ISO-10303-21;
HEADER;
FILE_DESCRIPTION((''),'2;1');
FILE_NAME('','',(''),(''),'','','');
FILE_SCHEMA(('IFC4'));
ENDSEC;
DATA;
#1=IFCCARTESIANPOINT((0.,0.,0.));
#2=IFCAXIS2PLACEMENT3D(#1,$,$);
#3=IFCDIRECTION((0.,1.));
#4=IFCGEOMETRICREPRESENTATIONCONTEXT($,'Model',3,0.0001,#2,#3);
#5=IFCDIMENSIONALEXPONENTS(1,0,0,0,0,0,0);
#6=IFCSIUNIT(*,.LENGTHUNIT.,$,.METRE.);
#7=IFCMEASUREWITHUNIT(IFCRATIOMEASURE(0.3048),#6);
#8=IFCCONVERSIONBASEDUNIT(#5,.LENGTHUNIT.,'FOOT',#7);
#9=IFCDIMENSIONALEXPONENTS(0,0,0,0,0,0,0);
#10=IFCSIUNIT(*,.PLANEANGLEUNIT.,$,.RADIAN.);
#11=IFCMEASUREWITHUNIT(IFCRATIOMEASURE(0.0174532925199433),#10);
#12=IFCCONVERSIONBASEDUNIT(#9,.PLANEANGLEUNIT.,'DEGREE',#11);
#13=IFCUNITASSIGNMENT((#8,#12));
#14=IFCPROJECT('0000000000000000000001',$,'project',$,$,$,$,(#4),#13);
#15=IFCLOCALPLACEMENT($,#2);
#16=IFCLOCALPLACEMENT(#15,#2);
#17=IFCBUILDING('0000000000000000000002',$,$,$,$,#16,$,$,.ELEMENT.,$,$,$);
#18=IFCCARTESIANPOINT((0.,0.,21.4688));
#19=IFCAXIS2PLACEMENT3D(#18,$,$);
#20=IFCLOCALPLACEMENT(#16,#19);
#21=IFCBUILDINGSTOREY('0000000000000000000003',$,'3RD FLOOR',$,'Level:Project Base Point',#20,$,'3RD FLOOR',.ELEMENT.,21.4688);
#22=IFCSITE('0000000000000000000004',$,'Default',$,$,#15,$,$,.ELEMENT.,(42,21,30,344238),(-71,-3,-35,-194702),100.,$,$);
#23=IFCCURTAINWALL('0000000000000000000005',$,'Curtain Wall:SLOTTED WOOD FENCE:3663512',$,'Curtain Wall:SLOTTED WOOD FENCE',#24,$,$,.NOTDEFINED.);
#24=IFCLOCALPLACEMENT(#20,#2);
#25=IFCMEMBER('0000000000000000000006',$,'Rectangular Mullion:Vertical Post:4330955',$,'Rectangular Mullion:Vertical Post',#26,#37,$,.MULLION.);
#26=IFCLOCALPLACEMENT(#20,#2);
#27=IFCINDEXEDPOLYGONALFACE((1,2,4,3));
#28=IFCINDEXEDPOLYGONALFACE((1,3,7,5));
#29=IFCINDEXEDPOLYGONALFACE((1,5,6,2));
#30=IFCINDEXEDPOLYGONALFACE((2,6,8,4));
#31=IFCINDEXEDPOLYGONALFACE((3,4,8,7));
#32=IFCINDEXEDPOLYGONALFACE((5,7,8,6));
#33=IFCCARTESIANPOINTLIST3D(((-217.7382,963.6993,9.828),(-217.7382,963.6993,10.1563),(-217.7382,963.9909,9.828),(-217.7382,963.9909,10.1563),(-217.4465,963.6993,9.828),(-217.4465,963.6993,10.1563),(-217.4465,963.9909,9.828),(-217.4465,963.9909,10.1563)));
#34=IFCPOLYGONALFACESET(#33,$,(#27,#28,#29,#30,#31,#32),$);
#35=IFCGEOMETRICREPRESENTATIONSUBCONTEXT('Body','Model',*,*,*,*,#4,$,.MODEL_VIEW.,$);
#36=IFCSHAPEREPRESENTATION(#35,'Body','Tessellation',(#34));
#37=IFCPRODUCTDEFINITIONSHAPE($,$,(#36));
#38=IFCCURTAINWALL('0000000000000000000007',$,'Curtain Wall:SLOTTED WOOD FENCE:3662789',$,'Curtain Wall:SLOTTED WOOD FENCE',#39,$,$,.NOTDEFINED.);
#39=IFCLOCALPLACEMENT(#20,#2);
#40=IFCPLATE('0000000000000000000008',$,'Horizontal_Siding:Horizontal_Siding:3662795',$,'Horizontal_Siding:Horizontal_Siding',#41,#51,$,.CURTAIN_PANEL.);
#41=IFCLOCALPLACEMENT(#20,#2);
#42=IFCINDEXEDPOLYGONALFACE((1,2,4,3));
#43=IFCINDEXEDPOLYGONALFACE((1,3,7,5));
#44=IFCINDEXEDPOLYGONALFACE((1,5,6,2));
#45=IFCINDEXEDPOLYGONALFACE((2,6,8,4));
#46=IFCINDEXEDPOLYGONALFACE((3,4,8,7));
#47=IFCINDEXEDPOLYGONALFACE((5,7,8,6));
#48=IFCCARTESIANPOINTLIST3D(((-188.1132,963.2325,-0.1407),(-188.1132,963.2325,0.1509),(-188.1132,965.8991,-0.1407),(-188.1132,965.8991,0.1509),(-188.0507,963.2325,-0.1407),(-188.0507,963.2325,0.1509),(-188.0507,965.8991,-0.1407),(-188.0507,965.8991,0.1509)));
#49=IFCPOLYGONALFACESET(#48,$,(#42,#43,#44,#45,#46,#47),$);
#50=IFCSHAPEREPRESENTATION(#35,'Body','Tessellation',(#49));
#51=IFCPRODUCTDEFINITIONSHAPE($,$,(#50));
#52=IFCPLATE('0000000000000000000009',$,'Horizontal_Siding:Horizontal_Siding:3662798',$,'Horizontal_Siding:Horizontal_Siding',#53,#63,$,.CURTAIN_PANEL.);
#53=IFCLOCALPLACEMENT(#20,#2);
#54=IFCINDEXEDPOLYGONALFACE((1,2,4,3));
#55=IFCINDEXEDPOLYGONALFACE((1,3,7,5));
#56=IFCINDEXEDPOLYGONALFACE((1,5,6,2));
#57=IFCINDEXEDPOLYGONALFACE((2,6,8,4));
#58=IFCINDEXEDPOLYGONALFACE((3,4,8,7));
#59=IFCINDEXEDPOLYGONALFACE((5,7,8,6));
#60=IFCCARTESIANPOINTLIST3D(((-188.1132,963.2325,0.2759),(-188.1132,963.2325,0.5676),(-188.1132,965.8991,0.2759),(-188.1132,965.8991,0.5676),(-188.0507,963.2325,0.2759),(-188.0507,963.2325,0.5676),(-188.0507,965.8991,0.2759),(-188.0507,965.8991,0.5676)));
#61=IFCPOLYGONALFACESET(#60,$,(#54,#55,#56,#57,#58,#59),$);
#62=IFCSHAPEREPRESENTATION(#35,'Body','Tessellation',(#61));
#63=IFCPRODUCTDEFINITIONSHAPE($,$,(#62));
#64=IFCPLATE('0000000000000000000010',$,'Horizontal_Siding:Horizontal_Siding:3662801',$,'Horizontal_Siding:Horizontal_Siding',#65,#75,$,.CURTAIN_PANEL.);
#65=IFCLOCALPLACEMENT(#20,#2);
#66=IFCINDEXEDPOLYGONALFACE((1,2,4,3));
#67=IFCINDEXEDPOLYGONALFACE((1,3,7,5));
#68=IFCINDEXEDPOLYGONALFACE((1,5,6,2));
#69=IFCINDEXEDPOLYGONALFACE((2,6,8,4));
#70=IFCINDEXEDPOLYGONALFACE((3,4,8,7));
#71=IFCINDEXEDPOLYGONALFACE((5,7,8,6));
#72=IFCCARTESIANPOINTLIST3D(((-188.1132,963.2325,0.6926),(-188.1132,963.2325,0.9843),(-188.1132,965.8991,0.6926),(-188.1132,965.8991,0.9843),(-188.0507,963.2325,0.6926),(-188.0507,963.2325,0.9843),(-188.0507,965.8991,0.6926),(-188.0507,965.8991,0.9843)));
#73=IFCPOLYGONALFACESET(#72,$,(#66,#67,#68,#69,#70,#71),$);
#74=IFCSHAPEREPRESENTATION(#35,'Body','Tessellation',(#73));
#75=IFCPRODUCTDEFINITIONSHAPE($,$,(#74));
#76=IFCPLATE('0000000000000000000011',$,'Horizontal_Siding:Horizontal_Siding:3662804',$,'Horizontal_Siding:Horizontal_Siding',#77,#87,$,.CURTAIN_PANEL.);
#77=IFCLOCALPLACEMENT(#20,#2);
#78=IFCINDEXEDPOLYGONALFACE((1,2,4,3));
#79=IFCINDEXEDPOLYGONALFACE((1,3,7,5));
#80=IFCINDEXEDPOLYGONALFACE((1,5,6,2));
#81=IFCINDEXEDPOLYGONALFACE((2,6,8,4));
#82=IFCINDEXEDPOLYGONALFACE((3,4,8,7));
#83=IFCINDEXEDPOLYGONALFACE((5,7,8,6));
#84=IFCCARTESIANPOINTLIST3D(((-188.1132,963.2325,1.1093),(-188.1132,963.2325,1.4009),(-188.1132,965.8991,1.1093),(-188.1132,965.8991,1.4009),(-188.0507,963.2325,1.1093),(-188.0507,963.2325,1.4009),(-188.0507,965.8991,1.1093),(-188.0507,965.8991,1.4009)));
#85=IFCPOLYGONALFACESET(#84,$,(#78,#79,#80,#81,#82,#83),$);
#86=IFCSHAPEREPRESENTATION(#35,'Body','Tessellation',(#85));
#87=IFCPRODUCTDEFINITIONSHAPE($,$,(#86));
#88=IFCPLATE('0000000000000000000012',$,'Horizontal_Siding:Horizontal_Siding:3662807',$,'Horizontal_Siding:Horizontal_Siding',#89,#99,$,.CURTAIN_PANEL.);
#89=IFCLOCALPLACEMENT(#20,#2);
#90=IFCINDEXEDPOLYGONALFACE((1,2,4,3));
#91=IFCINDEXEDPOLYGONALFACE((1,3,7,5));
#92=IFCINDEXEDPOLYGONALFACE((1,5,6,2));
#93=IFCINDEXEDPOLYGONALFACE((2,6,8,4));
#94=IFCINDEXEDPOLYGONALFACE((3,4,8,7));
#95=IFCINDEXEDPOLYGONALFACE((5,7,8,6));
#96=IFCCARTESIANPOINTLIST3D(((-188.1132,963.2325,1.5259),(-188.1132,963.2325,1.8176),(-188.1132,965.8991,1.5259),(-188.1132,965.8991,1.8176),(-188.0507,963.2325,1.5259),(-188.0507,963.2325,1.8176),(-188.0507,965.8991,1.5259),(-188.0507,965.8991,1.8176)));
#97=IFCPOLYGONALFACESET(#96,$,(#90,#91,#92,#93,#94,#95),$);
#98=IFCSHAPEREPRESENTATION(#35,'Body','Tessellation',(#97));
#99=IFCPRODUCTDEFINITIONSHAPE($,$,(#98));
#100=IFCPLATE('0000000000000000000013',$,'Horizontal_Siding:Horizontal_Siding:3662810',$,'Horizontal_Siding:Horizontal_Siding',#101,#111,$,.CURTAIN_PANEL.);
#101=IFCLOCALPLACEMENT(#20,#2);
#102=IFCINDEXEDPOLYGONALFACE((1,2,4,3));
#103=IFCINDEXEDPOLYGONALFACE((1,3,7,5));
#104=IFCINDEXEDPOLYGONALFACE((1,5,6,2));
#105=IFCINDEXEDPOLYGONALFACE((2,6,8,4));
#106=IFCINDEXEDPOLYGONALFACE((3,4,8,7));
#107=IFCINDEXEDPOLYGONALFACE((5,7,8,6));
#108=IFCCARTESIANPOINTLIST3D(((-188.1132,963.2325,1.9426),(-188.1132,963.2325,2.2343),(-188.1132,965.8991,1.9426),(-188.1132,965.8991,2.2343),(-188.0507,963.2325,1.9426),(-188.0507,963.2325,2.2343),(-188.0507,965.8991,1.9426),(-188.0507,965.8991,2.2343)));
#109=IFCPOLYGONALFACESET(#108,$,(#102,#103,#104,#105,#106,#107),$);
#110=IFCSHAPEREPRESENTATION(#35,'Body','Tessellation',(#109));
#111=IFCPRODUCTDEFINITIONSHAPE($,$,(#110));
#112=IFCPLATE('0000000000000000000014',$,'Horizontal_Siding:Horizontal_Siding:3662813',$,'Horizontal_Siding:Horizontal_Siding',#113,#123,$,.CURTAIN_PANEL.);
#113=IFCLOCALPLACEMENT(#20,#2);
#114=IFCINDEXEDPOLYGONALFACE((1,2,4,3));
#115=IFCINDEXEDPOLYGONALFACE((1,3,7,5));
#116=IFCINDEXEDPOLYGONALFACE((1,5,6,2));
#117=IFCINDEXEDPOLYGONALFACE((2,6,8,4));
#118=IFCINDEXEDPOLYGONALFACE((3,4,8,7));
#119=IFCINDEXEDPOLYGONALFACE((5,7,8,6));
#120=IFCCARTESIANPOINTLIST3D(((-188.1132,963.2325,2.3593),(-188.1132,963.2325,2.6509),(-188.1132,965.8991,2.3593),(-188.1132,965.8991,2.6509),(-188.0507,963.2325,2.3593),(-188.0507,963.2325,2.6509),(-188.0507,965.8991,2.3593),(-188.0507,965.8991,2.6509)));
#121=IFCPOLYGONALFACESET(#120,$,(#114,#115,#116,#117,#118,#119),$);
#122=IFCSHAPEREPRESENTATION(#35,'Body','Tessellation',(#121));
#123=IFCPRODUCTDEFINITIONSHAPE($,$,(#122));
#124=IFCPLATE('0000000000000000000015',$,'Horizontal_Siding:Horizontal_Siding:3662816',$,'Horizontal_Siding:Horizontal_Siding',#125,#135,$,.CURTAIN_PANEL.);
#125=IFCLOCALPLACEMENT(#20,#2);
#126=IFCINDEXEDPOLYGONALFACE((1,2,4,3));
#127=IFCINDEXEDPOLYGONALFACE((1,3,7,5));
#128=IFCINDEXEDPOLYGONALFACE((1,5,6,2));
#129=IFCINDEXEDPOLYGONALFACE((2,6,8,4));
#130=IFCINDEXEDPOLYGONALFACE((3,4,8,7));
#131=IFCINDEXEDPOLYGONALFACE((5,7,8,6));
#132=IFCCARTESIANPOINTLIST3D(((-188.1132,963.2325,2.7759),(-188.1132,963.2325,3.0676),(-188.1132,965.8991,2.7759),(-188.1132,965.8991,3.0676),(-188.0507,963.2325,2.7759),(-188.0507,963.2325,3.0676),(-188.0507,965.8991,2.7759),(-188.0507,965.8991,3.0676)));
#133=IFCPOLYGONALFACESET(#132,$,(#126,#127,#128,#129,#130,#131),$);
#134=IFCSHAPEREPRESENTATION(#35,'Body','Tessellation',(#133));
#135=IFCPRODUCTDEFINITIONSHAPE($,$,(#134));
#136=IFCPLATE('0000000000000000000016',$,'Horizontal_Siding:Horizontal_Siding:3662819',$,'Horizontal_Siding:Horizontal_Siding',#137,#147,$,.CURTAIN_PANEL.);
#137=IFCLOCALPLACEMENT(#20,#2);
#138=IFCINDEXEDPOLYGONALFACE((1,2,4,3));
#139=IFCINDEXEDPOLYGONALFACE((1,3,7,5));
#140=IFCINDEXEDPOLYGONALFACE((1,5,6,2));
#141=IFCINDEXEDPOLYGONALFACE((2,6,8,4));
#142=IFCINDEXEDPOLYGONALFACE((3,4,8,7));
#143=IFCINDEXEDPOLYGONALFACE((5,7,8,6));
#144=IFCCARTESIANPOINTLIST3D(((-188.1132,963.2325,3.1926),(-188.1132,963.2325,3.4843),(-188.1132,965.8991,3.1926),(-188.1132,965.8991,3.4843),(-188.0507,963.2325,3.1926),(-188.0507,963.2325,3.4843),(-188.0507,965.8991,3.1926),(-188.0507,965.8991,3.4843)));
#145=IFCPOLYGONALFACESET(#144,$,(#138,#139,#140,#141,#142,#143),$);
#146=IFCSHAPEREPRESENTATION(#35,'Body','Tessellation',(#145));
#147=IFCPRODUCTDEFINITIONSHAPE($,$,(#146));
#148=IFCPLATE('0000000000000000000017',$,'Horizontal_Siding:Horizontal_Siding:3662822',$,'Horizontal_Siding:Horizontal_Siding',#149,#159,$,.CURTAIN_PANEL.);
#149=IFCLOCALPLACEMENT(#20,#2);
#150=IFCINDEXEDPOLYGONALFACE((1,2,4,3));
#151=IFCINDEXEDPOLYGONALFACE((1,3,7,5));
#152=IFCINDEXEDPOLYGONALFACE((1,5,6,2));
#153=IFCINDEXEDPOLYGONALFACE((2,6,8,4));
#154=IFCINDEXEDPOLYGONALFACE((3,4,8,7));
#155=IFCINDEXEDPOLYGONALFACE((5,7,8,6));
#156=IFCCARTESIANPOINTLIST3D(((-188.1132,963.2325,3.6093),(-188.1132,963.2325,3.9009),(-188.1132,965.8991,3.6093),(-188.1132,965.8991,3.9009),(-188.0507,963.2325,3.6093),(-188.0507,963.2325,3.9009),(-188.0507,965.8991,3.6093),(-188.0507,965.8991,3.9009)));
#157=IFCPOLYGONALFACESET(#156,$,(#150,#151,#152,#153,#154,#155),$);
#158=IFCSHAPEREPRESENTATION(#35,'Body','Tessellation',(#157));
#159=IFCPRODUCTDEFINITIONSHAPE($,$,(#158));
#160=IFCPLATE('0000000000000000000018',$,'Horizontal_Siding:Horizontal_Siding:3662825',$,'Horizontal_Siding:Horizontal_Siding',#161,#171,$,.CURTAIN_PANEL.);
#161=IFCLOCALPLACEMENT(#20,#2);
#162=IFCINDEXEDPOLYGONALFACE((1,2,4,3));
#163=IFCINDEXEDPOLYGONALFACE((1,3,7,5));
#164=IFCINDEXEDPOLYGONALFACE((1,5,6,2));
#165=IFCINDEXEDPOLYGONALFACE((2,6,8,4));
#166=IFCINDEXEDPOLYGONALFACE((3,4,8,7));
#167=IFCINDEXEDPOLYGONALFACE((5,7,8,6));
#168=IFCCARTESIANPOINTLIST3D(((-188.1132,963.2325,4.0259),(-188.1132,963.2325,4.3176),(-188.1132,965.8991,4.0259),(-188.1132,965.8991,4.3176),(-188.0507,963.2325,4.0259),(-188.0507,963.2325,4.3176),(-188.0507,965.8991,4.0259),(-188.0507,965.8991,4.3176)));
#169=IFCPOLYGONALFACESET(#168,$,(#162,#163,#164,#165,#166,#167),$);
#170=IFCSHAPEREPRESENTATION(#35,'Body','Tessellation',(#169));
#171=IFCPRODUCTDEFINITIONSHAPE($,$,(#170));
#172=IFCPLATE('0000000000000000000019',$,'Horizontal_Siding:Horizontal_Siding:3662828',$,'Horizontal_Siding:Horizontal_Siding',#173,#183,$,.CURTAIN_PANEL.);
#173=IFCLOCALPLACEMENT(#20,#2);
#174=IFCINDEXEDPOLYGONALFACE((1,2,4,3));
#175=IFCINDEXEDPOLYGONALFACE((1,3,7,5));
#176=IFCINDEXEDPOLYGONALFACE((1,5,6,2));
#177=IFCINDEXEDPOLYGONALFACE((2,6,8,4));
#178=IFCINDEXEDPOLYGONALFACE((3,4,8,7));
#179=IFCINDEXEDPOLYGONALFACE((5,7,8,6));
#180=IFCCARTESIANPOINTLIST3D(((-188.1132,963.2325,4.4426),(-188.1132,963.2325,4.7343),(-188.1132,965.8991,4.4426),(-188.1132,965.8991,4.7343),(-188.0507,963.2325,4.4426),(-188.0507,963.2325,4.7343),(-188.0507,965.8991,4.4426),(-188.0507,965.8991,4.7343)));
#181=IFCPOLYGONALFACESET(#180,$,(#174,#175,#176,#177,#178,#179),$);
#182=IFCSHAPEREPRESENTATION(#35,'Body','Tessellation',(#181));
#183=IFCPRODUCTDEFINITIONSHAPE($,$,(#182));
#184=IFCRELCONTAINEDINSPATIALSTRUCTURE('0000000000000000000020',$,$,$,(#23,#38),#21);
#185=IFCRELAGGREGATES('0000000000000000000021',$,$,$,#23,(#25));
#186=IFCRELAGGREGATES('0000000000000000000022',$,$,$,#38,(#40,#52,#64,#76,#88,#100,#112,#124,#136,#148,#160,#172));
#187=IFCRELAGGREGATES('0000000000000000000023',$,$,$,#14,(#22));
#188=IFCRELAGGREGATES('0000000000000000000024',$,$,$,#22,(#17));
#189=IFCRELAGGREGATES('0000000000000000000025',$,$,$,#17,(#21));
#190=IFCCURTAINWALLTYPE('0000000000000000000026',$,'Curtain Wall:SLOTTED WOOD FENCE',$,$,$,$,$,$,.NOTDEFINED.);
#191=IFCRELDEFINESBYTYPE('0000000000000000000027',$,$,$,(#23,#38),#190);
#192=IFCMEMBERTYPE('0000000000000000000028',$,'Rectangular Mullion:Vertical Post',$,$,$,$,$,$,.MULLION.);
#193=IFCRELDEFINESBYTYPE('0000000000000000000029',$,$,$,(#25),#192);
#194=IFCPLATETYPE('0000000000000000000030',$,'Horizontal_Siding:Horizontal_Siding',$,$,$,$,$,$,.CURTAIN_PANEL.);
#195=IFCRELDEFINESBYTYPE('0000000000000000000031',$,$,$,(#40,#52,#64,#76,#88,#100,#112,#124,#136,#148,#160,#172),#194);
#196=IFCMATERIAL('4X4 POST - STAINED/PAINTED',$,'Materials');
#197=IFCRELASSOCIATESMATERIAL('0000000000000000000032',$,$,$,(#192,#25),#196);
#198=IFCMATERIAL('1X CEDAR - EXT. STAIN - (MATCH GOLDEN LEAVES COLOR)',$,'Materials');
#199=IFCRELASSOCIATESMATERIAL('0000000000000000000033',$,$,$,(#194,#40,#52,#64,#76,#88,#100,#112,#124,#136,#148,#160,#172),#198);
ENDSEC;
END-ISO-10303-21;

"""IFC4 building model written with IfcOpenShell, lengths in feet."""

from ifc_helpers import new_model, entity, si_unit, converted_unit, direction, frame, origin, origin_2d_with_axis, place, context, subcontext, project, spatial, rectangle, extrude, source, transform, mapped, material, material_profile, profile_set, profile_usage, type_object, type_shapes, element, aggregate, save


model = new_model("IFC4")

# Units and contexts
model_context = context("Model", 3, precision=0.0001, world=origin(), true_north=direction((0.0, 1.0)))
body_context = subcontext(model_context, "Body", "Model", "MODEL_VIEW")
ifc_project = project(units=[converted_unit("LENGTHUNIT", "FOOT", entity("IfcRatioMeasure", 0.3048), si_unit("LENGTHUNIT", "METRE"), dimensions=[1, 0, 0, 0, 0, 0, 0]), converted_unit("PLANEANGLEUNIT", "DEGREE", entity("IfcRatioMeasure", 0.0174532925199433), si_unit("PLANEANGLEUNIT", "RADIAN"), dimensions=[0, 0, 0, 0, 0, 0, 0])], contexts=[model_context])

# Site, building, storey
site_placement = place(None, origin())
site = spatial("IfcSite", under=ifc_project, at=site_placement, Name="Default", CompositionType="ELEMENT", RefLatitude=(42, 21, 30, 344238), RefLongitude=(-71, -3, -35, -194702), RefElevation=100.0)
building_placement = place(site_placement, origin())
building = spatial("IfcBuilding", under=site, at=building_placement, CompositionType="ELEMENT")
storey_placement = place(building_placement, frame((0.0, 0.0, 21.4688)))
storey = spatial("IfcBuildingStorey", under=building, at=storey_placement, Name="3RD FLOOR", ObjectType="Level:Project Base Point", LongName="3RD FLOOR", CompositionType="ELEMENT", Elevation=21.4688)

# Curtain wall, member
curtain_wall_type = type_object("IfcCurtainWallType", Name="Curtain Wall:SLOTTED WOOD FENCE", PredefinedType="NOTDEFINED")
curtain_wall_1_placement = place(storey_placement, frame((0.0, 0.0, -21.4688)))
curtain_wall_1 = element("IfcCurtainWall", 1, at=curtain_wall_1_placement, inside=storey, type_object=curtain_wall_type, Name="Curtain Wall:SLOTTED WOOD FENCE:3663512", ObjectType="Curtain Wall:SLOTTED WOOD FENCE", PredefinedType="NOTDEFINED")
ifc_material_1 = material(Name="4X4 POST - STAINED/PAINTED", Category="Materials")
ifc_material_profile = material_profile(ifc_material_1, rectangle(XDim=0.2917, YDim=0.2917, at=origin_2d_with_axis()), Name="Vertical Post")
ifc_profile_set = profile_set([ifc_material_profile], Name="Vertical Post")
ifc_profile_usage_1 = profile_usage(ifc_profile_set)
member_type_1 = type_object("IfcMemberType", Name="Rectangular Mullion:Vertical Post", PredefinedType="MULLION", material=ifc_profile_set)
shared_shape_1 = source(origin(), body_context, "Body", "SweptSolid", [
    extrude(rectangle(XDim=0.2917, YDim=0.2917, at=origin_2d_with_axis()), frame((0.0, -0.2083, -0.3282), z_axis=(0.0, 0.0, 1.0), x_axis=(0.0, -1.0, 0.0)), (0.0, 0.0, 1.0), 0.3282),
])
type_shapes(member_type_1, [shared_shape_1])
member_1_placement = place(storey_placement, frame((-217.8007, 963.8451, 9.828), z_axis=(0.0, 0.0, -1.0), x_axis=(0.0, -1.0, 0.0)))
member_1 = element("IfcMember", 2, at=member_1_placement, type_object=member_type_1, material=ifc_profile_usage_1, Name="Rectangular Mullion:Vertical Post:4330955", ObjectType="Rectangular Mullion:Vertical Post", PredefinedType="MULLION", context=body_context, shape_type="MappedRepresentation", body=[
    mapped(shared_shape_1, transform((0.0, 0.0, 0.0), scale=1.0)),
])
aggregate(curtain_wall_1, [member_1])

# Curtain wall, plates
curtain_wall_2_placement = place(storey_placement, frame((0.0, 0.0, -21.4688)))
curtain_wall_2 = element("IfcCurtainWall", 3, at=curtain_wall_2_placement, inside=storey, type_object=curtain_wall_type, Name="Curtain Wall:SLOTTED WOOD FENCE:3662789", ObjectType="Curtain Wall:SLOTTED WOOD FENCE", PredefinedType="NOTDEFINED")
ifc_material_2 = material(Name="1X CEDAR - EXT. STAIN - (MATCH GOLDEN LEAVES COLOR)", Category="Materials")
plate_type = type_object("IfcPlateType", Name="Horizontal_Siding:Horizontal_Siding", PredefinedType="CURTAIN_PANEL", material=ifc_material_2)
shared_shape_2 = source(origin(), body_context, "Body", "SweptSolid", [
    extrude(rectangle(XDim=0.0625, YDim=2.6667, at=origin_2d_with_axis()), frame((1.3333, 0.0312, 0.0), z_axis=(0.0, 0.0, 1.0), x_axis=(0.0, 1.0, 0.0)), (0.0, 0.0, 1.0), 0.2917),
])
type_shapes(plate_type, [shared_shape_2])
plate_1_placement = place(curtain_wall_2_placement, frame((-188.1132, 965.8991, 21.328), z_axis=(0.0, 0.0, 1.0), x_axis=(0.0, -1.0, 0.0)))
plate_1 = element("IfcPlate", 4, at=plate_1_placement, type_object=plate_type, material=ifc_material_2, Name="Horizontal_Siding:Horizontal_Siding:3662795", ObjectType="Horizontal_Siding:Horizontal_Siding", PredefinedType="CURTAIN_PANEL", context=body_context, shape_type="MappedRepresentation", body=[
    mapped(shared_shape_2, transform((0.0, 0.0, 0.0), scale=1.0)),
])
plate_2_placement = place(curtain_wall_2_placement, frame((-188.1132, 965.8991, 21.7447), z_axis=(0.0, 0.0, 1.0), x_axis=(0.0, -1.0, 0.0)))
plate_2 = element("IfcPlate", 5, at=plate_2_placement, type_object=plate_type, material=ifc_material_2, Name="Horizontal_Siding:Horizontal_Siding:3662798", ObjectType="Horizontal_Siding:Horizontal_Siding", PredefinedType="CURTAIN_PANEL", context=body_context, shape_type="MappedRepresentation", body=[
    mapped(shared_shape_2, transform((0.0, 0.0, 0.0), scale=1.0)),
])
plate_3_placement = place(curtain_wall_2_placement, frame((-188.1132, 965.8991, 22.1613), z_axis=(0.0, 0.0, 1.0), x_axis=(0.0, -1.0, 0.0)))
plate_3 = element("IfcPlate", 6, at=plate_3_placement, type_object=plate_type, material=ifc_material_2, Name="Horizontal_Siding:Horizontal_Siding:3662801", ObjectType="Horizontal_Siding:Horizontal_Siding", PredefinedType="CURTAIN_PANEL", context=body_context, shape_type="MappedRepresentation", body=[
    mapped(shared_shape_2, transform((0.0, 0.0, 0.0), scale=1.0)),
])
plate_4_placement = place(curtain_wall_2_placement, frame((-188.1132, 965.8991, 22.578), z_axis=(0.0, 0.0, 1.0), x_axis=(0.0, -1.0, 0.0)))
plate_4 = element("IfcPlate", 7, at=plate_4_placement, type_object=plate_type, material=ifc_material_2, Name="Horizontal_Siding:Horizontal_Siding:3662804", ObjectType="Horizontal_Siding:Horizontal_Siding", PredefinedType="CURTAIN_PANEL", context=body_context, shape_type="MappedRepresentation", body=[
    mapped(shared_shape_2, transform((0.0, 0.0, 0.0), scale=1.0)),
])
plate_5_placement = place(curtain_wall_2_placement, frame((-188.1132, 965.8991, 22.9947), z_axis=(0.0, 0.0, 1.0), x_axis=(0.0, -1.0, 0.0)))
plate_5 = element("IfcPlate", 8, at=plate_5_placement, type_object=plate_type, material=ifc_material_2, Name="Horizontal_Siding:Horizontal_Siding:3662807", ObjectType="Horizontal_Siding:Horizontal_Siding", PredefinedType="CURTAIN_PANEL", context=body_context, shape_type="MappedRepresentation", body=[
    mapped(shared_shape_2, transform((0.0, 0.0, 0.0), scale=1.0)),
])
plate_6_placement = place(curtain_wall_2_placement, frame((-188.1132, 965.8991, 23.4113), z_axis=(0.0, 0.0, 1.0), x_axis=(0.0, -1.0, 0.0)))
plate_6 = element("IfcPlate", 9, at=plate_6_placement, type_object=plate_type, material=ifc_material_2, Name="Horizontal_Siding:Horizontal_Siding:3662810", ObjectType="Horizontal_Siding:Horizontal_Siding", PredefinedType="CURTAIN_PANEL", context=body_context, shape_type="MappedRepresentation", body=[
    mapped(shared_shape_2, transform((0.0, 0.0, 0.0), scale=1.0)),
])
plate_7_placement = place(curtain_wall_2_placement, frame((-188.1132, 965.8991, 23.828), z_axis=(0.0, 0.0, 1.0), x_axis=(0.0, -1.0, 0.0)))
plate_7 = element("IfcPlate", 10, at=plate_7_placement, type_object=plate_type, material=ifc_material_2, Name="Horizontal_Siding:Horizontal_Siding:3662813", ObjectType="Horizontal_Siding:Horizontal_Siding", PredefinedType="CURTAIN_PANEL", context=body_context, shape_type="MappedRepresentation", body=[
    mapped(shared_shape_2, transform((0.0, 0.0, 0.0), scale=1.0)),
])
plate_8_placement = place(curtain_wall_2_placement, frame((-188.1132, 965.8991, 24.2447), z_axis=(0.0, 0.0, 1.0), x_axis=(0.0, -1.0, 0.0)))
plate_8 = element("IfcPlate", 11, at=plate_8_placement, type_object=plate_type, material=ifc_material_2, Name="Horizontal_Siding:Horizontal_Siding:3662816", ObjectType="Horizontal_Siding:Horizontal_Siding", PredefinedType="CURTAIN_PANEL", context=body_context, shape_type="MappedRepresentation", body=[
    mapped(shared_shape_2, transform((0.0, 0.0, 0.0), scale=1.0)),
])
plate_9_placement = place(curtain_wall_2_placement, frame((-188.1132, 965.8991, 24.6613), z_axis=(0.0, 0.0, 1.0), x_axis=(0.0, -1.0, 0.0)))
plate_9 = element("IfcPlate", 12, at=plate_9_placement, type_object=plate_type, material=ifc_material_2, Name="Horizontal_Siding:Horizontal_Siding:3662819", ObjectType="Horizontal_Siding:Horizontal_Siding", PredefinedType="CURTAIN_PANEL", context=body_context, shape_type="MappedRepresentation", body=[
    mapped(shared_shape_2, transform((0.0, 0.0, 0.0), scale=1.0)),
])
plate_10_placement = place(curtain_wall_2_placement, frame((-188.1132, 965.8991, 25.078), z_axis=(0.0, 0.0, 1.0), x_axis=(0.0, -1.0, 0.0)))
plate_10 = element("IfcPlate", 13, at=plate_10_placement, type_object=plate_type, material=ifc_material_2, Name="Horizontal_Siding:Horizontal_Siding:3662822", ObjectType="Horizontal_Siding:Horizontal_Siding", PredefinedType="CURTAIN_PANEL", context=body_context, shape_type="MappedRepresentation", body=[
    mapped(shared_shape_2, transform((0.0, 0.0, 0.0), scale=1.0)),
])
plate_11_placement = place(curtain_wall_2_placement, frame((-188.1132, 965.8991, 25.4947), z_axis=(0.0, 0.0, 1.0), x_axis=(0.0, -1.0, 0.0)))
plate_11 = element("IfcPlate", 14, at=plate_11_placement, type_object=plate_type, material=ifc_material_2, Name="Horizontal_Siding:Horizontal_Siding:3662825", ObjectType="Horizontal_Siding:Horizontal_Siding", PredefinedType="CURTAIN_PANEL", context=body_context, shape_type="MappedRepresentation", body=[
    mapped(shared_shape_2, transform((0.0, 0.0, 0.0), scale=1.0)),
])
plate_12_placement = place(curtain_wall_2_placement, frame((-188.1132, 965.8991, 25.9113), z_axis=(0.0, 0.0, 1.0), x_axis=(0.0, -1.0, 0.0)))
plate_12 = element("IfcPlate", 15, at=plate_12_placement, type_object=plate_type, material=ifc_material_2, Name="Horizontal_Siding:Horizontal_Siding:3662828", ObjectType="Horizontal_Siding:Horizontal_Siding", PredefinedType="CURTAIN_PANEL", context=body_context, shape_type="MappedRepresentation", body=[
    mapped(shared_shape_2, transform((0.0, 0.0, 0.0), scale=1.0)),
])
aggregate(curtain_wall_2, [plate_1, plate_2, plate_3, plate_4, plate_5, plate_6, plate_7, plate_8, plate_9, plate_10, plate_11, plate_12])

save(model, "model.ifc")
